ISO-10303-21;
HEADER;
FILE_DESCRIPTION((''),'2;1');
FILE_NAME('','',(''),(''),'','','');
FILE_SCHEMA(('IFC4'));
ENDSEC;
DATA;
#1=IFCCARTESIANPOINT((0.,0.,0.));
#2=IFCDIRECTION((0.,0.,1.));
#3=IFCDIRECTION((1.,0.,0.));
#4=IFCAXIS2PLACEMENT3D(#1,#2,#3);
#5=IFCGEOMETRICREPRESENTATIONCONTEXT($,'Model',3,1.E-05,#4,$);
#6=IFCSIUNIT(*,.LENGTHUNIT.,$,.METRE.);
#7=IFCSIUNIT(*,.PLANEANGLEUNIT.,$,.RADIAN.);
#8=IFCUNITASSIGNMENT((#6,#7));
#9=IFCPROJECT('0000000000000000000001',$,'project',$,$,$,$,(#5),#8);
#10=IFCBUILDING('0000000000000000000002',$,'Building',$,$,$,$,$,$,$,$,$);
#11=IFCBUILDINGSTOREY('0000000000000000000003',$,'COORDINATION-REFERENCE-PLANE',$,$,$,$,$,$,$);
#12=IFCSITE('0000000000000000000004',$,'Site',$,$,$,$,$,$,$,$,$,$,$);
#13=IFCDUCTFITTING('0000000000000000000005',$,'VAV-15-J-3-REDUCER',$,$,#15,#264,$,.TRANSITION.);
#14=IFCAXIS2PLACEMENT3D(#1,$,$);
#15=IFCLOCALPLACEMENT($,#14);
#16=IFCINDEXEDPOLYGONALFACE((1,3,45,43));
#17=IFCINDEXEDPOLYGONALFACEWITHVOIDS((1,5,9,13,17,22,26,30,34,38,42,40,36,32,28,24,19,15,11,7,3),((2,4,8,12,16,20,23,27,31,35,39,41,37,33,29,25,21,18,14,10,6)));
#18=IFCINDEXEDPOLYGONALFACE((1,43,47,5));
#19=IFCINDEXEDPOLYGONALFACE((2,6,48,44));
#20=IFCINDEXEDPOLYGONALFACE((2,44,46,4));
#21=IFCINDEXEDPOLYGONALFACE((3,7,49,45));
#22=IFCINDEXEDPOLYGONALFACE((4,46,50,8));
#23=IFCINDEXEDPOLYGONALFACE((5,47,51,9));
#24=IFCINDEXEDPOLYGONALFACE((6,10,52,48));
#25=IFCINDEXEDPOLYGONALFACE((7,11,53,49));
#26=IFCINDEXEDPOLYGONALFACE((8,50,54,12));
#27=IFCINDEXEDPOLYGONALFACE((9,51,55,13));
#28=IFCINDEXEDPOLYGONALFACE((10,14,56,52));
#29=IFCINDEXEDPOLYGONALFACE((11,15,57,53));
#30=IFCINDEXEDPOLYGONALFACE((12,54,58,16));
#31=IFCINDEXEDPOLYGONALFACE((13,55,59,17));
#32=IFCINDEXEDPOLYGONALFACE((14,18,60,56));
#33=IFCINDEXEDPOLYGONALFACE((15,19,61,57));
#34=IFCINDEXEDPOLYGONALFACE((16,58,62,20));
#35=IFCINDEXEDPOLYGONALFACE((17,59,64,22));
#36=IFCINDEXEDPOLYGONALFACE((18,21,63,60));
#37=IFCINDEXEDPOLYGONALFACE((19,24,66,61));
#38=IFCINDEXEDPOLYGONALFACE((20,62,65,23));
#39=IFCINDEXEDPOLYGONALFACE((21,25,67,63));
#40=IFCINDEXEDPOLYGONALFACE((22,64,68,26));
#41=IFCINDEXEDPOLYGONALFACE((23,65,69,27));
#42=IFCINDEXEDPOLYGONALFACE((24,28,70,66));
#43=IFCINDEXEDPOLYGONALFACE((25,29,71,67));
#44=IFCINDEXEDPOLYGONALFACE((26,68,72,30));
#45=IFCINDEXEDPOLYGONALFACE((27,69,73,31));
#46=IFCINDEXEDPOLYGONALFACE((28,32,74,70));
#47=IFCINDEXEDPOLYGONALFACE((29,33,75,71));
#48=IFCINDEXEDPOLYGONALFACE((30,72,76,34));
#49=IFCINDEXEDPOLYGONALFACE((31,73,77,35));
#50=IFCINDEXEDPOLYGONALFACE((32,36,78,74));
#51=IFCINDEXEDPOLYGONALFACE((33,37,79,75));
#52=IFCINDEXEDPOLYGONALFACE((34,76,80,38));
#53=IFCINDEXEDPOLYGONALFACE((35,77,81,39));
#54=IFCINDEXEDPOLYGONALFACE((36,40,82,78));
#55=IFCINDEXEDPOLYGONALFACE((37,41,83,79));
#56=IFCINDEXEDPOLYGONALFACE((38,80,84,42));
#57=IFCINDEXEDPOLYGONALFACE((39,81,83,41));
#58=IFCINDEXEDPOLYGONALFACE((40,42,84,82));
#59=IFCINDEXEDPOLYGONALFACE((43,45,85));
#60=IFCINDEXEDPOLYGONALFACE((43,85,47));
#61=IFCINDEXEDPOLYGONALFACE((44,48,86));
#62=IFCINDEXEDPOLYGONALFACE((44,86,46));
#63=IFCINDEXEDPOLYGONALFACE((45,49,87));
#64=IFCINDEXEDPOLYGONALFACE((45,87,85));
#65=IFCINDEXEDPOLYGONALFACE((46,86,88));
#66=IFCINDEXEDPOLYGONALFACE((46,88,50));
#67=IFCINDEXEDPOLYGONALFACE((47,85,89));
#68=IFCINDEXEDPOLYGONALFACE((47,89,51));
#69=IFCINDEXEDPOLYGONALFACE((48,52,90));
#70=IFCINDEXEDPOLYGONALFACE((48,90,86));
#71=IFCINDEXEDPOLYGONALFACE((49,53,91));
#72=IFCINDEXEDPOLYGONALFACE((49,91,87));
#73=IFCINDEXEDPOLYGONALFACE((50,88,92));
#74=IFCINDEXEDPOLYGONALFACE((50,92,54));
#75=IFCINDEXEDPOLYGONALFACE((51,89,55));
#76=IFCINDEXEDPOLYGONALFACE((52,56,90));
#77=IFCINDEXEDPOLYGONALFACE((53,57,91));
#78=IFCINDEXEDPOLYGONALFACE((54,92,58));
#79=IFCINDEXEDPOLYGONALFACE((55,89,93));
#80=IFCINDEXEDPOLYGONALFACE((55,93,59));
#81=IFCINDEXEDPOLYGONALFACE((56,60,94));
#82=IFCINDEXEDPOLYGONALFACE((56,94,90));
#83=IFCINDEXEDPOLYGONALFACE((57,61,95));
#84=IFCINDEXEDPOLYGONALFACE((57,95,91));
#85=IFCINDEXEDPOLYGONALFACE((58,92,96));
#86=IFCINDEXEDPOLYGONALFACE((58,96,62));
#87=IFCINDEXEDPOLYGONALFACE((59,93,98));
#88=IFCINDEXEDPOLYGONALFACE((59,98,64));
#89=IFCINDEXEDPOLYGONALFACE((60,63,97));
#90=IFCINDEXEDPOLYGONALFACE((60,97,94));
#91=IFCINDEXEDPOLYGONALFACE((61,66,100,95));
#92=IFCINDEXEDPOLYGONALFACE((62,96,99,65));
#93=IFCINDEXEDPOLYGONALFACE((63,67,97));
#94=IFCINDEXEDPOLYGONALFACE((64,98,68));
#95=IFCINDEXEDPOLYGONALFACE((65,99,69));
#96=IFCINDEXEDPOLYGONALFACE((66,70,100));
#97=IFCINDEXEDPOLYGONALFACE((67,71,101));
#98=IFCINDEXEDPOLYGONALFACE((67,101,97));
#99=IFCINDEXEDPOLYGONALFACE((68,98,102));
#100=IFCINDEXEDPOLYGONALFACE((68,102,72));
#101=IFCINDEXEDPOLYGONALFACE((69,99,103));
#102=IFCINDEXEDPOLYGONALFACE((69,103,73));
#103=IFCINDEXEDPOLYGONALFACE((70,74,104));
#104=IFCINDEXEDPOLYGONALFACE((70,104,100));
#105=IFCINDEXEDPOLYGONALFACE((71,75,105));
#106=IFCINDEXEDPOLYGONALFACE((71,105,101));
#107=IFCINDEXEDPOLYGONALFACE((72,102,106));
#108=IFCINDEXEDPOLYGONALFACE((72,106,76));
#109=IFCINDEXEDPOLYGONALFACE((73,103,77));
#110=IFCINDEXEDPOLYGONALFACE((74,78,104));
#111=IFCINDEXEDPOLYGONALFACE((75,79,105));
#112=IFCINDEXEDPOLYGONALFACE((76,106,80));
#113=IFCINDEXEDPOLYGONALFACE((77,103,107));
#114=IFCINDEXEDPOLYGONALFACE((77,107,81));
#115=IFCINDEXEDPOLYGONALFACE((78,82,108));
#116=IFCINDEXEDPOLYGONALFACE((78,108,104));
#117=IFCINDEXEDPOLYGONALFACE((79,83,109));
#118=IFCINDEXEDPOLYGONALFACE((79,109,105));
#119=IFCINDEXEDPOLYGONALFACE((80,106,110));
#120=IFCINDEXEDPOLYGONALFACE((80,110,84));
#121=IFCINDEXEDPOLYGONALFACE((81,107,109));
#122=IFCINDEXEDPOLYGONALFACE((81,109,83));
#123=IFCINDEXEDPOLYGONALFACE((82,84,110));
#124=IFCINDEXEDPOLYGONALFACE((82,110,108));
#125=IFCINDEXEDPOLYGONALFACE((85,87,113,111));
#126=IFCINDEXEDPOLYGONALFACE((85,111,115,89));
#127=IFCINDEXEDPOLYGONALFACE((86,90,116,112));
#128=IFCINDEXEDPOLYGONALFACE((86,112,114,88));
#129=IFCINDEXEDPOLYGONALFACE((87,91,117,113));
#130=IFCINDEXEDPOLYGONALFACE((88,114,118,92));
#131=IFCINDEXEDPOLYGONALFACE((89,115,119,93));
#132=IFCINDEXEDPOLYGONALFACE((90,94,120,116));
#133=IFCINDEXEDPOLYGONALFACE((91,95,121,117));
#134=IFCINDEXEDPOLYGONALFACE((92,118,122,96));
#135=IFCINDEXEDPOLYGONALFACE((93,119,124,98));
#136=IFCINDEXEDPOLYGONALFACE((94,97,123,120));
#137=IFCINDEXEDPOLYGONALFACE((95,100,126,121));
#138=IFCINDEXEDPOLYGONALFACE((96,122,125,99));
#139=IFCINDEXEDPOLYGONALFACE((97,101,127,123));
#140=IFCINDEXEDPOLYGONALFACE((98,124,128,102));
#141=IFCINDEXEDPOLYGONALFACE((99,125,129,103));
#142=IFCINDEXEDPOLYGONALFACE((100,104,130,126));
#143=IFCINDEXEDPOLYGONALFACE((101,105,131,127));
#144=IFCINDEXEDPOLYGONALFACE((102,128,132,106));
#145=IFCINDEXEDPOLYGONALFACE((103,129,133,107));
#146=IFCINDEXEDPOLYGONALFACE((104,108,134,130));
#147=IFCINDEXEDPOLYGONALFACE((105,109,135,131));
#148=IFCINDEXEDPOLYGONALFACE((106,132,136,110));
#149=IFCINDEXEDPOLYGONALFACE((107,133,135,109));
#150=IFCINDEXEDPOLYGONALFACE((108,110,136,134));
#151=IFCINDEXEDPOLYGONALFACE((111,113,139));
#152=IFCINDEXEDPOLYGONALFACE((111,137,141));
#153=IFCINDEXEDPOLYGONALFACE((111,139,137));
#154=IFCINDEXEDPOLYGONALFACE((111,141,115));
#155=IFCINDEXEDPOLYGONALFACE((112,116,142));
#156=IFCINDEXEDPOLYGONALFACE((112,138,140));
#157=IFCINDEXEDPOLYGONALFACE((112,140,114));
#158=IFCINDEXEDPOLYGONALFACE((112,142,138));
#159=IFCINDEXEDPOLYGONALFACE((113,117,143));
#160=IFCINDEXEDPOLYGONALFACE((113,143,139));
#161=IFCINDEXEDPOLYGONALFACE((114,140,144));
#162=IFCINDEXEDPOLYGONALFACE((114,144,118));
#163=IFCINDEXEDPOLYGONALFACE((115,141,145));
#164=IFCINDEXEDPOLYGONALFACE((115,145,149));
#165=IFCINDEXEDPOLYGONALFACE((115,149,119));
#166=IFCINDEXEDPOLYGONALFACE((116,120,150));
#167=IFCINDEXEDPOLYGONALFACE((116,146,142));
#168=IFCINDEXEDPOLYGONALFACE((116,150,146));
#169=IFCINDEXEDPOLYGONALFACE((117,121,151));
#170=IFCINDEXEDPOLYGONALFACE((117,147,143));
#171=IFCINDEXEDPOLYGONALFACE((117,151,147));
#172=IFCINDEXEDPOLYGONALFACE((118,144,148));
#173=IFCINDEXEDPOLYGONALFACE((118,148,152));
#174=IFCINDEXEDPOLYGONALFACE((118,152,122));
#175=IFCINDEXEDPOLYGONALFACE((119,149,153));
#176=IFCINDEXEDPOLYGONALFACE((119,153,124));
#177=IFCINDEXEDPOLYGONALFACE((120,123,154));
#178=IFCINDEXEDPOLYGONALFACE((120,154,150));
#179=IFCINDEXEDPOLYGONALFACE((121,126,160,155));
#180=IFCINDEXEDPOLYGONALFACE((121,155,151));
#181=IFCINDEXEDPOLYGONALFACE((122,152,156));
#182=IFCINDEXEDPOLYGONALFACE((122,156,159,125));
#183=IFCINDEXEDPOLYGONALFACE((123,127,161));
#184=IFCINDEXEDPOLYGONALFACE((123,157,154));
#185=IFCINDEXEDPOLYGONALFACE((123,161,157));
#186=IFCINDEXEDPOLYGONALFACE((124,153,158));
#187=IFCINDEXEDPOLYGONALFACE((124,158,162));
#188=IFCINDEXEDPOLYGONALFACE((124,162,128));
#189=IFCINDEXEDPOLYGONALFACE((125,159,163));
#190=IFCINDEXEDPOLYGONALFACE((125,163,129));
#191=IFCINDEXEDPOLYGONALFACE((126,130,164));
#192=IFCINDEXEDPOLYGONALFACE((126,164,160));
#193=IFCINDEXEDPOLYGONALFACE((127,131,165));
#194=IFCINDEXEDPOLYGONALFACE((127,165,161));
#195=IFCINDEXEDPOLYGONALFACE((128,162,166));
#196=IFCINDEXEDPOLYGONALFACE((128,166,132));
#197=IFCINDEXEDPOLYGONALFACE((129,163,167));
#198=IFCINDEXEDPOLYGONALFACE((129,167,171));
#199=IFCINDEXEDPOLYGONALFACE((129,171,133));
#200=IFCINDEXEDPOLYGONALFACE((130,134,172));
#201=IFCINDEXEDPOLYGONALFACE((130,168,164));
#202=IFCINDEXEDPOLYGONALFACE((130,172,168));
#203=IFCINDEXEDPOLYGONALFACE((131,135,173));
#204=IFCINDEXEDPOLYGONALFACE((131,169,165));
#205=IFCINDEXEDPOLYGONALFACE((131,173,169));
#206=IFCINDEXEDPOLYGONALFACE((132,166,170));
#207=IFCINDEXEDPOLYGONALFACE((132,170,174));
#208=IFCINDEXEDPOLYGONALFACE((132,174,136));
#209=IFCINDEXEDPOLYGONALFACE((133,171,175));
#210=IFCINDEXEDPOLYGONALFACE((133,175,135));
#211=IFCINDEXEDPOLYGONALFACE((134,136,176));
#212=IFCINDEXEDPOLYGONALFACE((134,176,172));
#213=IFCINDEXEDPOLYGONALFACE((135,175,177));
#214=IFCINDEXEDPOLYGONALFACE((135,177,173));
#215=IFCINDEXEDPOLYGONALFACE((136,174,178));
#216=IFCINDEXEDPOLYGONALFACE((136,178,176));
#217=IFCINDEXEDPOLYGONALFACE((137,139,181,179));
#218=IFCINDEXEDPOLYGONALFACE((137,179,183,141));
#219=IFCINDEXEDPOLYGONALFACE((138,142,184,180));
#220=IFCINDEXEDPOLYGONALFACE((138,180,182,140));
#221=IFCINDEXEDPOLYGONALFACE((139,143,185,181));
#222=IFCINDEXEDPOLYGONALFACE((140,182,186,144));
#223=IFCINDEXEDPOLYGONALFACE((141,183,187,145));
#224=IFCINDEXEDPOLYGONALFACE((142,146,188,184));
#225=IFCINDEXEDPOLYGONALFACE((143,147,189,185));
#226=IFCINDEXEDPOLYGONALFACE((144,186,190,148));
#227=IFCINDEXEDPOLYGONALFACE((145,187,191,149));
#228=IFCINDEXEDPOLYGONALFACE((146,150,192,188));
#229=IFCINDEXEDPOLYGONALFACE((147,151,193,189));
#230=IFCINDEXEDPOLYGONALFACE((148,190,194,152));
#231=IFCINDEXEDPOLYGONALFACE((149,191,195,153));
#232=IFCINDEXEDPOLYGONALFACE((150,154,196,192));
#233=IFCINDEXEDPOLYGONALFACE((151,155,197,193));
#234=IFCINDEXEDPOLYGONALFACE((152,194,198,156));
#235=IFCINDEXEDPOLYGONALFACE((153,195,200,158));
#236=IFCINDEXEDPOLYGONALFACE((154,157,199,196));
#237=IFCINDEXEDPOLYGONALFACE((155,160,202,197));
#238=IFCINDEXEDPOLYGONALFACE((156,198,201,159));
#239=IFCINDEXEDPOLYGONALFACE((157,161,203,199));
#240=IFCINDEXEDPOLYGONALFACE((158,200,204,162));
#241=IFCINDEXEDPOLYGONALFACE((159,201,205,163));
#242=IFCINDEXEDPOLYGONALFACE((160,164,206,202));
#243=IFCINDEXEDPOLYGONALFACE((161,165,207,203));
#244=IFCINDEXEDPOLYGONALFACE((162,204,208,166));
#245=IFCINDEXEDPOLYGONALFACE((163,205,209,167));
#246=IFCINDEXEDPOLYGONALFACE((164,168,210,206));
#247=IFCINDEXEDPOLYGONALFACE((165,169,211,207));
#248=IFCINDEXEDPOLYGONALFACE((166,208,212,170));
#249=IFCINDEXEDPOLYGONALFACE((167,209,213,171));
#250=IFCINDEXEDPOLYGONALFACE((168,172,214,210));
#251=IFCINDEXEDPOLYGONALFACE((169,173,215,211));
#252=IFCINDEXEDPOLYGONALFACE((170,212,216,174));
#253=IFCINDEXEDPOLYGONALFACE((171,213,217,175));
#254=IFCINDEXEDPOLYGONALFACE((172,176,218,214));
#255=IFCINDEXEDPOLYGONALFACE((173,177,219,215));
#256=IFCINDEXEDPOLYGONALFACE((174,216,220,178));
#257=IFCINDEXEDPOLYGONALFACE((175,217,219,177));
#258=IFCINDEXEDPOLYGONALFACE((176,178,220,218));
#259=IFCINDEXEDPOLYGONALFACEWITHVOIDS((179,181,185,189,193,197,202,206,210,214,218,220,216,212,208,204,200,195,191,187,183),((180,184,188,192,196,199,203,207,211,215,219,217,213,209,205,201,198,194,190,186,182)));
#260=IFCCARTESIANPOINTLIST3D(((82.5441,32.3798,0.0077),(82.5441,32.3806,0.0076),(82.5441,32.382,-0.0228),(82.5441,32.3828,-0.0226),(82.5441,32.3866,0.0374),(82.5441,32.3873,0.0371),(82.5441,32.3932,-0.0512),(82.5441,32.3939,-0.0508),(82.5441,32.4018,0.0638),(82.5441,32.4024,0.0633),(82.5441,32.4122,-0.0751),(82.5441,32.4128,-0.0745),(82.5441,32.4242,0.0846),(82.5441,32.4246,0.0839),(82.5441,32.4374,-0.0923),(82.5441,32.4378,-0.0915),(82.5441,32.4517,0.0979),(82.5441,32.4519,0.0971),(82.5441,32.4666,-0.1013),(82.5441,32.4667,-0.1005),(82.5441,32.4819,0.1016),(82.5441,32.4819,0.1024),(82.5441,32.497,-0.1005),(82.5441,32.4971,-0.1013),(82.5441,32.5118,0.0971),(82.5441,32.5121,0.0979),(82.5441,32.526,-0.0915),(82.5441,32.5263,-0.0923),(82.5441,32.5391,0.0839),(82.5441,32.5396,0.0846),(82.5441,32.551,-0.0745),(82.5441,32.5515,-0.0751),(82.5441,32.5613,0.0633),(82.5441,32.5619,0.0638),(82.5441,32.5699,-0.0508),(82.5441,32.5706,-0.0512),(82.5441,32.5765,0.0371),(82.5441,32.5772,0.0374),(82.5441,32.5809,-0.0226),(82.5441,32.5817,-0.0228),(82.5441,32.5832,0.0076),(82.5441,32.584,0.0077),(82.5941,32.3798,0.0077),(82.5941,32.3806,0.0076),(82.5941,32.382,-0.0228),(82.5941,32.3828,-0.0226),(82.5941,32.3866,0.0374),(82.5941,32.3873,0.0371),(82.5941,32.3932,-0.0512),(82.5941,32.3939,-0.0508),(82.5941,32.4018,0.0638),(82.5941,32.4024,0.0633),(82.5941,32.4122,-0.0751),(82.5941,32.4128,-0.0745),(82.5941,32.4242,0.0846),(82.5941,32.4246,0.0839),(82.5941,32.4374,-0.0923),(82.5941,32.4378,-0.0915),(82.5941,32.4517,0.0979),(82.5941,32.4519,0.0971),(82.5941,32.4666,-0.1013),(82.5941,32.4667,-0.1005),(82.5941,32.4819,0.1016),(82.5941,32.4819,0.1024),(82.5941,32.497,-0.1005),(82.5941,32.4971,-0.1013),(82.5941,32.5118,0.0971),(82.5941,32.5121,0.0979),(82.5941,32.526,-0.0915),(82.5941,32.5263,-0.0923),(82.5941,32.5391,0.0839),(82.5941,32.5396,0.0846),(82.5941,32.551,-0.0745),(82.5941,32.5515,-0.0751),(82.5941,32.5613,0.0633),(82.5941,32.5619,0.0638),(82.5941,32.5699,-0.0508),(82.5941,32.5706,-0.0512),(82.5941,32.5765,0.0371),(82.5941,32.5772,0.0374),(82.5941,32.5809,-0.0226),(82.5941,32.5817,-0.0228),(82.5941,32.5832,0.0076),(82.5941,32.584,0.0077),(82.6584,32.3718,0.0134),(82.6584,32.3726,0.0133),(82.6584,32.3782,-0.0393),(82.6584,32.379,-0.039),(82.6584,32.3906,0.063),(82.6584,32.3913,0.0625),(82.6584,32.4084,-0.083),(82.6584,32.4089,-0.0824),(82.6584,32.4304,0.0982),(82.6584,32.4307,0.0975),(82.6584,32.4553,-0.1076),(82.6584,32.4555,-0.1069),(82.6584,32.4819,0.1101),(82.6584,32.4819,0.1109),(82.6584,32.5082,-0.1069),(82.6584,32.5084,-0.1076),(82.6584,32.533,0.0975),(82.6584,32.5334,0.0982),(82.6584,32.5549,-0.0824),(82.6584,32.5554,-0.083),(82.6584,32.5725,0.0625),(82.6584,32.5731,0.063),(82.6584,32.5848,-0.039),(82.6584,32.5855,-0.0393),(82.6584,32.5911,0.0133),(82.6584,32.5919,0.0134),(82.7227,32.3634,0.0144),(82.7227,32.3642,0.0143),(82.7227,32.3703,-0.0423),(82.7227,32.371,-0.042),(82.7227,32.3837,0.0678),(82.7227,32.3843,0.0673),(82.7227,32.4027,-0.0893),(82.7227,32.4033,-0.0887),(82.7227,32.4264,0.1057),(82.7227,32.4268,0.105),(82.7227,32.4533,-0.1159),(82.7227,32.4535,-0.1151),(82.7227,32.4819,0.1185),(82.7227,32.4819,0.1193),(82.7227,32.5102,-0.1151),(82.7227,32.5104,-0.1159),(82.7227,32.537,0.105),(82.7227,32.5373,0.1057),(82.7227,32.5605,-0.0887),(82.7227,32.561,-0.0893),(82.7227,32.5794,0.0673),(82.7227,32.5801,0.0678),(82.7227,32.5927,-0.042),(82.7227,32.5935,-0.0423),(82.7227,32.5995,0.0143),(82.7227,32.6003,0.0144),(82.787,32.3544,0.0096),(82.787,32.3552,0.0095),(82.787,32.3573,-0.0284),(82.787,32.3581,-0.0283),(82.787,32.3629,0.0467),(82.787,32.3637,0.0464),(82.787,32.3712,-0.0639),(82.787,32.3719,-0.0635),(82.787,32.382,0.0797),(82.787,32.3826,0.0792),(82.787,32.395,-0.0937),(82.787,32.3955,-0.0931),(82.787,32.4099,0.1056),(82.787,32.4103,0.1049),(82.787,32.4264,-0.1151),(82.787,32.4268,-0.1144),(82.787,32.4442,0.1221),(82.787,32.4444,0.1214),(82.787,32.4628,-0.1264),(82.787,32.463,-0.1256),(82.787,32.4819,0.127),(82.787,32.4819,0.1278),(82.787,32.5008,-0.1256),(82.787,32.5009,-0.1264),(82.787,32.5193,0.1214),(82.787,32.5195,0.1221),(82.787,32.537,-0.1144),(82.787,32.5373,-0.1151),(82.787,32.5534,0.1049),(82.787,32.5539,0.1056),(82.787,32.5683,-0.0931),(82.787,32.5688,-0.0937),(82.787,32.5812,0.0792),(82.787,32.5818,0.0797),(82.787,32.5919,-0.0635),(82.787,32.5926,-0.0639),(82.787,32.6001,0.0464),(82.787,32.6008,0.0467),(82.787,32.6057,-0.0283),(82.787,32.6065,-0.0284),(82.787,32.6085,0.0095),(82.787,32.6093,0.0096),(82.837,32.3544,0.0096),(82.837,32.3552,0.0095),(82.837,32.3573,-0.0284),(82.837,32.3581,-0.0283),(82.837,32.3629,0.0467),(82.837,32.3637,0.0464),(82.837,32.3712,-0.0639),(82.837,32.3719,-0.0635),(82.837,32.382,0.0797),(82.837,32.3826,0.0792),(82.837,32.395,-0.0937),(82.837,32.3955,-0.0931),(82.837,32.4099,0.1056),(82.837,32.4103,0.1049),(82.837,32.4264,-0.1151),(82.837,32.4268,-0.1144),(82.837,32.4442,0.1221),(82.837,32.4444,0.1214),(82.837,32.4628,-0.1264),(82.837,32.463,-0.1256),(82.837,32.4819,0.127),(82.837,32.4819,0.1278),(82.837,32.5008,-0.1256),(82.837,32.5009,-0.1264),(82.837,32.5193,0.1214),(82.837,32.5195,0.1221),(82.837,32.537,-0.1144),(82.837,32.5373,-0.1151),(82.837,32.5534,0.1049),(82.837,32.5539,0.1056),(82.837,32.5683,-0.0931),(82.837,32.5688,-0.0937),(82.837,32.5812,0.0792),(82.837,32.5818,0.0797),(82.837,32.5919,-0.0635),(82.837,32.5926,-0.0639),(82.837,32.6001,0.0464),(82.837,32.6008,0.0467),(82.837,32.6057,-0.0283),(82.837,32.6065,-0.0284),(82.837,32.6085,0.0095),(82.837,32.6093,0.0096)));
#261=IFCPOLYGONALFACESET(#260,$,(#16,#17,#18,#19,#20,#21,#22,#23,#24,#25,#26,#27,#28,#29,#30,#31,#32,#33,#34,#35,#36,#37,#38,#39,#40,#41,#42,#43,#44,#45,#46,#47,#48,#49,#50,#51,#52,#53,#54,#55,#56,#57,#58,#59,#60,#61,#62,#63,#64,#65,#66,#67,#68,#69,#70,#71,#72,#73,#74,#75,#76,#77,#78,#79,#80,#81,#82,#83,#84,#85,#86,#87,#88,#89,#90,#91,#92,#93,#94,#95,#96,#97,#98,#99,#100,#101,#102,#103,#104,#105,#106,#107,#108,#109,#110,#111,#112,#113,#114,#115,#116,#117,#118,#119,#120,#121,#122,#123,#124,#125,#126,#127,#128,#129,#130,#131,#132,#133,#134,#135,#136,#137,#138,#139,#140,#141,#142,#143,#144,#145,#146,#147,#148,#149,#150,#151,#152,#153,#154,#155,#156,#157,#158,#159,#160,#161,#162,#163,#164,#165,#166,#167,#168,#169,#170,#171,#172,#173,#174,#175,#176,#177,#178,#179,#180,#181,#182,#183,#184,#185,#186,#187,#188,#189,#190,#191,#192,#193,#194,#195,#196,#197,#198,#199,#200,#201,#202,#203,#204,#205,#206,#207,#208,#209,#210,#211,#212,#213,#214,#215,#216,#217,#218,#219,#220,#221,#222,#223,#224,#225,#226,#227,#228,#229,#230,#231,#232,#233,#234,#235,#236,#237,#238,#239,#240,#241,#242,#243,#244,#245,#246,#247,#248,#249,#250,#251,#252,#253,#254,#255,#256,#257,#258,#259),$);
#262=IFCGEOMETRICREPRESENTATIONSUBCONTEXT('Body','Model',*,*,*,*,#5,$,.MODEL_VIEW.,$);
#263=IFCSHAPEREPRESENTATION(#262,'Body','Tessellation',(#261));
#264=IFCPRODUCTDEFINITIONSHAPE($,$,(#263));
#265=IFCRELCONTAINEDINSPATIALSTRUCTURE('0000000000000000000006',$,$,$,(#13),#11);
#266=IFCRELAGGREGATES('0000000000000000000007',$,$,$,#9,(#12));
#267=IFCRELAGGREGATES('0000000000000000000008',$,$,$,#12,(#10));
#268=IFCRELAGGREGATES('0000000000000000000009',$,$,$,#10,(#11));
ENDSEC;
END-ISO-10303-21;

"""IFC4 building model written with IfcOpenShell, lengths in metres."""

from ifc_helpers import new_model, entity, si_unit, frame, origin_with_axes, place, context, subcontext, project, spatial, element, save


model = new_model("IFC4")

# Units and contexts
model_context_1 = context("Model", 3, precision=1e-05, world=origin_with_axes())
body_context_1 = subcontext(model_context_1, "Body", "Model", "MODEL_VIEW")
ifc_project = project(units=[si_unit("LENGTHUNIT", "METRE"), si_unit("PLANEANGLEUNIT", "RADIAN")], contexts=[model_context_1])

# Site, building, storey
site = spatial("IfcSite", under=ifc_project, Name="Site")
building = spatial("IfcBuilding", under=site, Name="Building")
storey = spatial("IfcBuildingStorey", under=building, Name="COORDINATION-REFERENCE-PLANE")

# Duct fitting
for number, where, z_axis, x_axis, name in (
    (1, (82.837, 32.4819, 0.0), (0.0, -1.0, 0.0), (0.0, 0.0, 1.0), "VAV-15-J-3-REDUCER"),
):
    element("IfcDuctFitting", number, at=place(None, frame(where, z_axis=z_axis, x_axis=x_axis)), inside=storey, Name=name, PredefinedType="TRANSITION", context=body_context_1, shape_type="SweptSolid", body=[
        entity("IfcRevolvedAreaSolid", entity("IfcArbitraryClosedProfileDef", "AREA", None, entity("IfcPolyline", [entity("IfcCartesianPoint", [0.1278, 0.0]), entity("IfcCartesianPoint", [0.1278, 0.05]), entity("IfcCartesianPoint", [0.1024, 0.2429]), entity("IfcCartesianPoint", [0.1024, 0.2929]), entity("IfcCartesianPoint", [0.1016, 0.2929]), entity("IfcCartesianPoint", [0.1016, 0.2429]), entity("IfcCartesianPoint", [0.127, 0.05]), entity("IfcCartesianPoint", [0.127, 0.0]), entity("IfcCartesianPoint", [0.1278, 0.0])])), entity("IfcAxis2Placement3D", entity("IfcCartesianPoint", [0.0, 0.0, 0.0])), entity("IfcAxis1Placement", entity("IfcCartesianPoint", [0.0, 0.0, 0.0]), entity("IfcDirection", [0.0, 1.0, 0.0])), 6.283185),
    ])

save(model, "model.ifc")
